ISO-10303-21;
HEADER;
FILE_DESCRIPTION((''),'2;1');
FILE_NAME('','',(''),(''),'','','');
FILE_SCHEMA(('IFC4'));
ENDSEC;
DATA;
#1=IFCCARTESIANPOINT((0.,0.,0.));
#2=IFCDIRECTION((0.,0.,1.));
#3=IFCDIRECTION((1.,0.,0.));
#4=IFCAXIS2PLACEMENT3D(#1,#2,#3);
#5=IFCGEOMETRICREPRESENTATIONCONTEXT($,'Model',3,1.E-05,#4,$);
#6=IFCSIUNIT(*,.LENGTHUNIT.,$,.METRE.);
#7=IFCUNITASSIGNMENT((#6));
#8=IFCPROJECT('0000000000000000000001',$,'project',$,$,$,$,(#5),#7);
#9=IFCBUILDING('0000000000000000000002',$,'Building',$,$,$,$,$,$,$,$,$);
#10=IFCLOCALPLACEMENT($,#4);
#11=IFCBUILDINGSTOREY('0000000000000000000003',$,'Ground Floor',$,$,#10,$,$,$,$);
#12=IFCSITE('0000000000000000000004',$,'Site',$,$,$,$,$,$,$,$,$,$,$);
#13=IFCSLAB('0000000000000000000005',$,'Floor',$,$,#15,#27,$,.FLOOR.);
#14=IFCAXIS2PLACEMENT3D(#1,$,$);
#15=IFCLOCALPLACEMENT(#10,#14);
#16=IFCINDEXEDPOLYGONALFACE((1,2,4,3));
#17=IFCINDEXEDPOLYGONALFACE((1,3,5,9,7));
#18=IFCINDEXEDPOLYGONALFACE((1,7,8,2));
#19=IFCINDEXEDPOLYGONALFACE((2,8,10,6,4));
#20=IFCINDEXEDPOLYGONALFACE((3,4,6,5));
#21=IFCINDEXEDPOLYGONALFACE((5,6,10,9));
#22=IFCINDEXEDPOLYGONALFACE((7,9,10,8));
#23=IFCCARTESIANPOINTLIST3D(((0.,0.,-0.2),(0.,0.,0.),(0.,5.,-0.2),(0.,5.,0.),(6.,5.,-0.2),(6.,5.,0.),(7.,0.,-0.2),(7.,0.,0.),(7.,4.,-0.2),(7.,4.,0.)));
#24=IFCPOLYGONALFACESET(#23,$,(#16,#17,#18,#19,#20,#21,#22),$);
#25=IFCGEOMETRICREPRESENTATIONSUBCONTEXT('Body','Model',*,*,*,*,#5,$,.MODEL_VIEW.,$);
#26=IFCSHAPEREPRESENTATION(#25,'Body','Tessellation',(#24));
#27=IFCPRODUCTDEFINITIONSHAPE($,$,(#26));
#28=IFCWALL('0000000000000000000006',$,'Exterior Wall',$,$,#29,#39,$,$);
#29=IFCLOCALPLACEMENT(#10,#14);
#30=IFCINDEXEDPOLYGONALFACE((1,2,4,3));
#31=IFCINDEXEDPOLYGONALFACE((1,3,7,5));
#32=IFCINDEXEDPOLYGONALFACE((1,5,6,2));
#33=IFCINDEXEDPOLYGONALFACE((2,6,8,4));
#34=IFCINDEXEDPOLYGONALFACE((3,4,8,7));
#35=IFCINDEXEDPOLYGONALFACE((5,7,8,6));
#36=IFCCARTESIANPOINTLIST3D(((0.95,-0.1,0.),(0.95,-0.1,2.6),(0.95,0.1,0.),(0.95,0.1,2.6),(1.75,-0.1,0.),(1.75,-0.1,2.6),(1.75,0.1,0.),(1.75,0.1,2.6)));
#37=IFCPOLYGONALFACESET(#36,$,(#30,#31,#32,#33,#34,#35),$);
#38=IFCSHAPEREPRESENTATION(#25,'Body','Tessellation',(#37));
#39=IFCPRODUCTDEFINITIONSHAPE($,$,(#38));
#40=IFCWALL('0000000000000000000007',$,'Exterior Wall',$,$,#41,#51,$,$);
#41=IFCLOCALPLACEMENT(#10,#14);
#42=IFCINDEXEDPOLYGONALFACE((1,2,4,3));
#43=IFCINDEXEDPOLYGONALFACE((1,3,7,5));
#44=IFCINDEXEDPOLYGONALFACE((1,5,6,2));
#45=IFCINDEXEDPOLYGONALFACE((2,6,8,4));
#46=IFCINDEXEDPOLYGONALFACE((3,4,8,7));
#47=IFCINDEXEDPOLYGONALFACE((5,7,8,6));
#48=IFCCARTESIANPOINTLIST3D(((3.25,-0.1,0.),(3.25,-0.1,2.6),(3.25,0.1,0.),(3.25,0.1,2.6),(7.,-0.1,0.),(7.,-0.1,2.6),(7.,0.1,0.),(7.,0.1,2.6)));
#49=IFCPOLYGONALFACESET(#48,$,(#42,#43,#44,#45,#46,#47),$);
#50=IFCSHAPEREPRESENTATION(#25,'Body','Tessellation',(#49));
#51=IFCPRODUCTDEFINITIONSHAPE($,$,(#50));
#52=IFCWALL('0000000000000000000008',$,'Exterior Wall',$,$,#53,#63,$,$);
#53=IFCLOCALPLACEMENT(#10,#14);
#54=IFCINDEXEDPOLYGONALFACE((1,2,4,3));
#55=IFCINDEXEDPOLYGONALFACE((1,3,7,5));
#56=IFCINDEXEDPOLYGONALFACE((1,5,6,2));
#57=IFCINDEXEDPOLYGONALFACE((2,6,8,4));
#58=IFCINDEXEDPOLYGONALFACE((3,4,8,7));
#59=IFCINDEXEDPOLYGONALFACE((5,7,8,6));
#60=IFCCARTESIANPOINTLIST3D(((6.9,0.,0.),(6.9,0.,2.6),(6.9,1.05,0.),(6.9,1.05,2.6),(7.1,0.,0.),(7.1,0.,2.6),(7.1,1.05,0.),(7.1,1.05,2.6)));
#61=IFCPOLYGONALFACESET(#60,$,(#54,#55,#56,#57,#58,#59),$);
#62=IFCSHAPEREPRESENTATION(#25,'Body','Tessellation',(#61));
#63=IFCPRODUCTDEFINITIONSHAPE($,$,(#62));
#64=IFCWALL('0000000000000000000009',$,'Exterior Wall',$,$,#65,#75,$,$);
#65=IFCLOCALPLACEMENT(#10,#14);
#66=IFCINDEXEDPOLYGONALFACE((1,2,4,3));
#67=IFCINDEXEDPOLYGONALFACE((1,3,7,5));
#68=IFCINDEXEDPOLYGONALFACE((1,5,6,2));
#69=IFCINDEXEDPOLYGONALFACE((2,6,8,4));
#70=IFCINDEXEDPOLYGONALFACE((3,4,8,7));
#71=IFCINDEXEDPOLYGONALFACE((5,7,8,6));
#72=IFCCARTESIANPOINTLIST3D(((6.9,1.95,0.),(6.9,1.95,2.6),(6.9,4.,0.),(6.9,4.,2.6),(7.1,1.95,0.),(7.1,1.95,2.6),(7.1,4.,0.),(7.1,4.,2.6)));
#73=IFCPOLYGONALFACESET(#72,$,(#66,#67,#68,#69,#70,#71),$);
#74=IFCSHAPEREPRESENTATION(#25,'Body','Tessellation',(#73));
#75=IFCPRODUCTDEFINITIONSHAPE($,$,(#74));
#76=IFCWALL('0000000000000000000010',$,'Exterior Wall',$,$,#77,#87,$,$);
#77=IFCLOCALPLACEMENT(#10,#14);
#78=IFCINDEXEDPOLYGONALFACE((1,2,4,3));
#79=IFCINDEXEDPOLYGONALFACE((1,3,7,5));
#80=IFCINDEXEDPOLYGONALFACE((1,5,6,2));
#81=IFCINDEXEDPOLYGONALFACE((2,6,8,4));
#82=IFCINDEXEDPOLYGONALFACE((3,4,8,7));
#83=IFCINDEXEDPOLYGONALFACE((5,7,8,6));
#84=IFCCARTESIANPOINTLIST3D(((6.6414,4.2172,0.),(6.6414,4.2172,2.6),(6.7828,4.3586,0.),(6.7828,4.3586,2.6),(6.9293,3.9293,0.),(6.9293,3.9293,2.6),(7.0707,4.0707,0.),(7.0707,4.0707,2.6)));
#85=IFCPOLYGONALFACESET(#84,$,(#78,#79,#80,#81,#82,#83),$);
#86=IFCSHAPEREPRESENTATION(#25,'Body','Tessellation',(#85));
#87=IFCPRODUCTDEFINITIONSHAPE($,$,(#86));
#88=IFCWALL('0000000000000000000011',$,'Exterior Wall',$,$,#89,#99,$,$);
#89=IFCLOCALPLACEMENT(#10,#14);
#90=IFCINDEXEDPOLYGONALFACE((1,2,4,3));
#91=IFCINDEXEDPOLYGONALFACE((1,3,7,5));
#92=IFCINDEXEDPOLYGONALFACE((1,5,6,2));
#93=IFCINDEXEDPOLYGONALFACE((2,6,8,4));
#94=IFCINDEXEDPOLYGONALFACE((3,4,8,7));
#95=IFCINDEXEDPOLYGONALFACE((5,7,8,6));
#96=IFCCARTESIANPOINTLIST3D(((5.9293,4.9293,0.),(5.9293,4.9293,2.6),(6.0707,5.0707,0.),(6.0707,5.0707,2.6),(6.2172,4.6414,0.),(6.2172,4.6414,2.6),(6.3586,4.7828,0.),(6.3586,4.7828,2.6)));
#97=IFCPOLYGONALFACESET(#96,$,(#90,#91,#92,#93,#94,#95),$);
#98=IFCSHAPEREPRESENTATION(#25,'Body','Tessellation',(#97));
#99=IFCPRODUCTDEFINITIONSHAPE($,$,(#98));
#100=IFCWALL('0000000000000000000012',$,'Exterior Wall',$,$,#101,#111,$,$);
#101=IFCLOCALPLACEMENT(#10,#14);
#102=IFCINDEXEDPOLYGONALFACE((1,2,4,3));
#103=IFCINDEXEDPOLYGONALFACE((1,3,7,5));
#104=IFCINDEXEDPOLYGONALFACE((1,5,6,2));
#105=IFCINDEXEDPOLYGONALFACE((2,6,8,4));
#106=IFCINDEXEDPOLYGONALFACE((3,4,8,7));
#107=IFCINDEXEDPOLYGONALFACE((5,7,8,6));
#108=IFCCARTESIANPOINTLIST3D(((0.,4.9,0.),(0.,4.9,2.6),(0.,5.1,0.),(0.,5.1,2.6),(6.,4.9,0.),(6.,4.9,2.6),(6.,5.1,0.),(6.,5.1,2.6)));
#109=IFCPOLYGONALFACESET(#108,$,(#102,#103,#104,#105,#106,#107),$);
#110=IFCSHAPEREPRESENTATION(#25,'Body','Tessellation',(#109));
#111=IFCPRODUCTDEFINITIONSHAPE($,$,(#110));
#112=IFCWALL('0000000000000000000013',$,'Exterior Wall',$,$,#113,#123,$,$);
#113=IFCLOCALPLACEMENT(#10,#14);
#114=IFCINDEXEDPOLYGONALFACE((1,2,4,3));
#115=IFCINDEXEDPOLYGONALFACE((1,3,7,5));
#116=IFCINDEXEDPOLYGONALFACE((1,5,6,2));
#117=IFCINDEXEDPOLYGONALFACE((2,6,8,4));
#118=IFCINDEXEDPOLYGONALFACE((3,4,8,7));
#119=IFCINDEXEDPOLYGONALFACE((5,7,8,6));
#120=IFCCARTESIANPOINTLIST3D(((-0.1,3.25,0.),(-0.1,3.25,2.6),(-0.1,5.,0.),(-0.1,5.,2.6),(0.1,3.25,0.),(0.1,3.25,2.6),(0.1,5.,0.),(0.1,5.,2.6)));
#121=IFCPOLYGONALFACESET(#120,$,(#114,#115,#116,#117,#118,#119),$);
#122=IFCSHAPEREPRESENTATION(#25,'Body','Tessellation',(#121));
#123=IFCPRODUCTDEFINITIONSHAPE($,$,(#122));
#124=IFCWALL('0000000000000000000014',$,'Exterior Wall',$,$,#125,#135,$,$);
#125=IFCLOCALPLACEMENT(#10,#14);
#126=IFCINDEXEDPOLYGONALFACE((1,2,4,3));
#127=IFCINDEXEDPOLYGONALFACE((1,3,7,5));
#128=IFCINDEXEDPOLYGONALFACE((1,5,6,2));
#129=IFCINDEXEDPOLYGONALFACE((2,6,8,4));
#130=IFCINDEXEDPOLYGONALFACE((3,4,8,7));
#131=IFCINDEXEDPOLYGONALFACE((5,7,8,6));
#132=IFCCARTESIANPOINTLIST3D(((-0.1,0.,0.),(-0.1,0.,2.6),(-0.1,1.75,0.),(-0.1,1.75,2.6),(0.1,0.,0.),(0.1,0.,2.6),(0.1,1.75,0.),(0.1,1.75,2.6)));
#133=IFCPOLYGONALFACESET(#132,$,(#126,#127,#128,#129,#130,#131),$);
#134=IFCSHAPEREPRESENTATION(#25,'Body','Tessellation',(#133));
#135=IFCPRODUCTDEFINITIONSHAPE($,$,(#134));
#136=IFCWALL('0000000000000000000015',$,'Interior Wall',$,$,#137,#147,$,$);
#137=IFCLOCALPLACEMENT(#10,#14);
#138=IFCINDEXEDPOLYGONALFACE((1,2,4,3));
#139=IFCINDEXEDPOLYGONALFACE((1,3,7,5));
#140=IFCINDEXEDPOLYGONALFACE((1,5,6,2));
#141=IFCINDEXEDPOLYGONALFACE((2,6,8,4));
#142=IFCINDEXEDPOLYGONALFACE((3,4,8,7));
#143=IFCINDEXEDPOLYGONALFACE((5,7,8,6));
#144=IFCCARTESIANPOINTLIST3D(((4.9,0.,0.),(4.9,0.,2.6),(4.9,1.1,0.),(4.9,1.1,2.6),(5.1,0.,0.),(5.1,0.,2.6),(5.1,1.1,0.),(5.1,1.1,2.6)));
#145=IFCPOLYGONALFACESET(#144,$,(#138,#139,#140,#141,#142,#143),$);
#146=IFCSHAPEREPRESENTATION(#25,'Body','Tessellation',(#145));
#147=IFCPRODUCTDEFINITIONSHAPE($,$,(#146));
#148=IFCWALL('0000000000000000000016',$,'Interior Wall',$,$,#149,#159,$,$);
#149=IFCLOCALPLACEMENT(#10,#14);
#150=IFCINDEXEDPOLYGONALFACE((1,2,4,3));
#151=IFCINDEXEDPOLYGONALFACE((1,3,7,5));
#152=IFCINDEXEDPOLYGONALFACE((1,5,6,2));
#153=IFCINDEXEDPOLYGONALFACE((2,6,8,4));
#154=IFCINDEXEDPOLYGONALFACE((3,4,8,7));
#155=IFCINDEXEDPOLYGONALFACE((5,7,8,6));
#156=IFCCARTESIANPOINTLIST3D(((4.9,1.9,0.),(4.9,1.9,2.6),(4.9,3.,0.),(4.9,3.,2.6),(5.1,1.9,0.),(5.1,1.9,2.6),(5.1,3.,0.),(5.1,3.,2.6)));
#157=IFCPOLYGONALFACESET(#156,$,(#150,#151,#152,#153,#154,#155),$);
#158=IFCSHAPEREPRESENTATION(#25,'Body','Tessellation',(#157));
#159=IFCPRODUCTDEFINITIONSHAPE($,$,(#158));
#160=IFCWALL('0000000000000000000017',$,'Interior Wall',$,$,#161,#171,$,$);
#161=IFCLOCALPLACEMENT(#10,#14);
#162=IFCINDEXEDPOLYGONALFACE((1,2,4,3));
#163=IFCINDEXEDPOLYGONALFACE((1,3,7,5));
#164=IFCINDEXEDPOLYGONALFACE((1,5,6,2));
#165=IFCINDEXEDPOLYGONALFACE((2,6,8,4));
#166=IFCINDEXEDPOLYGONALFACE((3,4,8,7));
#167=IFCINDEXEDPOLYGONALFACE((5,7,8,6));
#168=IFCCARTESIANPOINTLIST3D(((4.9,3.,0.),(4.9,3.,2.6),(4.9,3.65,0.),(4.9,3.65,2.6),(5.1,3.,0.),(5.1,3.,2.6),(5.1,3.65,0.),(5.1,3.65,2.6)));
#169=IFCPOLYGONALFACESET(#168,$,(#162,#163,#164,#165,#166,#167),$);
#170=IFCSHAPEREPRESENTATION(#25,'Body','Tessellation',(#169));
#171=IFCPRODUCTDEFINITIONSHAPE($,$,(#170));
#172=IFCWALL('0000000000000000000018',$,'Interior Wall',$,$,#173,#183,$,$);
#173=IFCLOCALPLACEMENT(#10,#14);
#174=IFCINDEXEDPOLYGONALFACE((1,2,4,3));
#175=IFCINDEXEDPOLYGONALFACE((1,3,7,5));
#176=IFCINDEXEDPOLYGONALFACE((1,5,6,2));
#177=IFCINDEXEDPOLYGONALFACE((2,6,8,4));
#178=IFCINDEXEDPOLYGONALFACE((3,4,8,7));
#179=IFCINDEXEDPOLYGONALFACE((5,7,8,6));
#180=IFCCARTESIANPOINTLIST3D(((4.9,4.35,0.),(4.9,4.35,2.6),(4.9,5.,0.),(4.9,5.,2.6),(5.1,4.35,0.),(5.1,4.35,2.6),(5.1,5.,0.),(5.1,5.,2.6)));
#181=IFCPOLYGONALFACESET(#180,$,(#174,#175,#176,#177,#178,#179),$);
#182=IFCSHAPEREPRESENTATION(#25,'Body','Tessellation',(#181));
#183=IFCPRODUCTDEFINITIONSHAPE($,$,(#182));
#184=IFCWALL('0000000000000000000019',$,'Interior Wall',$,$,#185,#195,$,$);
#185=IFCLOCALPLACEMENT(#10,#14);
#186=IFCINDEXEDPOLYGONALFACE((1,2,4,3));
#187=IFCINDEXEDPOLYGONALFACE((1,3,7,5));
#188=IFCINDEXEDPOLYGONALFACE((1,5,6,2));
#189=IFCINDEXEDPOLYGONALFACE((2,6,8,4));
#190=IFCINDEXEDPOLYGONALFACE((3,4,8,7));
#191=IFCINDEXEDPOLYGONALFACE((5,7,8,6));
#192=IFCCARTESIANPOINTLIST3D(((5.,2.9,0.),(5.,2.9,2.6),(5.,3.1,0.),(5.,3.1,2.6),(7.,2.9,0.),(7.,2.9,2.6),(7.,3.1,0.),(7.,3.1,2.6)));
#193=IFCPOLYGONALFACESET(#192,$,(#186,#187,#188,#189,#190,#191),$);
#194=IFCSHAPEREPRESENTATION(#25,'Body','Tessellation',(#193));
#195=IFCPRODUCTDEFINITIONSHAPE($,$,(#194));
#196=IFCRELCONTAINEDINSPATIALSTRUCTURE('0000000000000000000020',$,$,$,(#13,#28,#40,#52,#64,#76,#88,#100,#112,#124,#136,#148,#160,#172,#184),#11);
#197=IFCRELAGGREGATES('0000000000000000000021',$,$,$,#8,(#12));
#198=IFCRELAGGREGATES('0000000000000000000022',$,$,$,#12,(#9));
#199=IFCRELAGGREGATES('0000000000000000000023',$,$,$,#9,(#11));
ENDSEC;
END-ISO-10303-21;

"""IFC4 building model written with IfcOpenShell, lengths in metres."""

from ifc_helpers import new_model, si_unit, frame, origin_with_axes, place, context, subcontext, project, spatial, indexed_curve, outline, extrude, element, save


model = new_model("IFC4")

# Units and contexts
model_context = context("Model", 3, precision=1e-05, world=origin_with_axes())
body_context = subcontext(model_context, "Body", "Model", "MODEL_VIEW")
ifc_project = project(units=[si_unit("LENGTHUNIT", "METRE")], contexts=[model_context])

# Site, building, storey
site = spatial("IfcSite", under=ifc_project, Name="Site")
building = spatial("IfcBuilding", under=site, Name="Building")
storey_placement = place(None, origin_with_axes())
storey = spatial("IfcBuildingStorey", under=building, at=storey_placement, Name="Ground Floor")

# Slab
slab_placement = place(storey_placement, frame((0.0, 0.0, -0.2), z_axis=(0.0, 0.0, 1.0), x_axis=(1.0, 0.0, 0.0)))
element("IfcSlab", 1, at=slab_placement, inside=storey, Name="Floor", PredefinedType="FLOOR", context=body_context, shape_type="SweptSolid", body=[
    extrude(outline(indexed_curve([(0.0, 0.0), (7.0, 0.0), (7.0, 4.0), (6.0, 5.0), (0.0, 5.0)])), None, (0.0, 0.0, 1.0), 0.2),
])

# Walls
wall_1_placement = place(storey_placement, frame((0.95, 0.0, 0.0), z_axis=(0.0, 0.0, 1.0), x_axis=(1.0, 0.0, 0.0)))
element("IfcWall", 2, at=wall_1_placement, inside=storey, Name="Exterior Wall", context=body_context, shape_type="SweptSolid", body=[
    extrude(outline(indexed_curve([(0.0, 0.0), (0.0, 0.2), (0.8, 0.2), (0.8, 0.0), (0.0, 0.0)], self_intersect=False)), frame((0.0, -0.1, 0.0), z_axis=(0.0, 0.0, 1.0), x_axis=(1.0, 0.0, 0.0)), (0.0, 0.0, 1.0), 2.6),
])
wall_2_placement = place(storey_placement, frame((3.25, 0.0, 0.0), z_axis=(0.0, 0.0, 1.0), x_axis=(1.0, 0.0, 0.0)))
element("IfcWall", 3, at=wall_2_placement, inside=storey, Name="Exterior Wall", context=body_context, shape_type="SweptSolid", body=[
    extrude(outline(indexed_curve([(0.0, 0.0), (0.0, 0.2), (3.75, 0.2), (3.75, 0.0), (0.0, 0.0)], self_intersect=False)), frame((0.0, -0.1, 0.0), z_axis=(0.0, 0.0, 1.0), x_axis=(1.0, 0.0, 0.0)), (0.0, 0.0, 1.0), 2.6),
])
wall_3_placement = place(storey_placement, frame((7.0, 0.0, 0.0), z_axis=(0.0, 0.0, 1.0), x_axis=(0.0, 1.0, 0.0)))
element("IfcWall", 4, at=wall_3_placement, inside=storey, Name="Exterior Wall", context=body_context, shape_type="SweptSolid", body=[
    extrude(outline(indexed_curve([(0.0, 0.0), (0.0, 0.2), (1.05, 0.2), (1.05, 0.0), (0.0, 0.0)], self_intersect=False)), frame((0.0, -0.1, 0.0), z_axis=(0.0, 0.0, 1.0), x_axis=(1.0, 0.0, 0.0)), (0.0, 0.0, 1.0), 2.6),
])
wall_4_placement = place(storey_placement, frame((7.0, 1.95, 0.0), z_axis=(0.0, 0.0, 1.0), x_axis=(0.0, 1.0, 0.0)))
element("IfcWall", 5, at=wall_4_placement, inside=storey, Name="Exterior Wall", context=body_context, shape_type="SweptSolid", body=[
    extrude(outline(indexed_curve([(0.0, 0.0), (0.0, 0.2), (2.05, 0.2), (2.05, 0.0), (0.0, 0.0)], self_intersect=False)), frame((0.0, -0.1, 0.0), z_axis=(0.0, 0.0, 1.0), x_axis=(1.0, 0.0, 0.0)), (0.0, 0.0, 1.0), 2.6),
])
wall_5_placement = place(storey_placement, frame((7.0, 4.0, 0.0), z_axis=(0.0, 0.0, 1.0), x_axis=(-0.707107, 0.707107, 0.0)))
element("IfcWall", 6, at=wall_5_placement, inside=storey, Name="Exterior Wall", context=body_context, shape_type="SweptSolid", body=[
    extrude(outline(indexed_curve([(0.0, 0.0), (0.0, 0.2), (0.4071, 0.2), (0.4071, 0.0), (0.0, 0.0)], self_intersect=False)), frame((0.0, -0.1, 0.0), z_axis=(0.0, 0.0, 1.0), x_axis=(1.0, 0.0, 0.0)), (0.0, 0.0, 1.0), 2.6),
])
wall_6_placement = place(storey_placement, frame((6.2879, 4.7121, 0.0), z_axis=(0.0, 0.0, 1.0), x_axis=(-0.707107, 0.707107, 0.0)))
element("IfcWall", 7, at=wall_6_placement, inside=storey, Name="Exterior Wall", context=body_context, shape_type="SweptSolid", body=[
    extrude(outline(indexed_curve([(0.0, 0.0), (0.0, 0.2), (0.4071, 0.2), (0.4071, 0.0), (0.0, 0.0)], self_intersect=False)), frame((0.0, -0.1, 0.0), z_axis=(0.0, 0.0, 1.0), x_axis=(1.0, 0.0, 0.0)), (0.0, 0.0, 1.0), 2.6),
])
wall_7_placement = place(storey_placement, frame((6.0, 5.0, 0.0), z_axis=(0.0, 0.0, 1.0), x_axis=(-1.0, 0.0, 0.0)))
element("IfcWall", 8, at=wall_7_placement, inside=storey, Name="Exterior Wall", context=body_context, shape_type="SweptSolid", body=[
    extrude(outline(indexed_curve([(0.0, 0.0), (0.0, 0.2), (6.0, 0.2), (6.0, 0.0), (0.0, 0.0)], self_intersect=False)), frame((0.0, -0.1, 0.0), z_axis=(0.0, 0.0, 1.0), x_axis=(1.0, 0.0, 0.0)), (0.0, 0.0, 1.0), 2.6),
])
for number, where, z_axis, x_axis, name in (
    (9, (0.0, 5.0, 0.0), (0.0, 0.0, 1.0), (0.0, -1.0, 0.0), "Exterior Wall"),
    (10, (0.0, 1.75, 0.0), (0.0, 0.0, 1.0), (0.0, -1.0, 0.0), "Exterior Wall"),
):
    element("IfcWall", number, at=place(storey_placement, frame(where, z_axis=z_axis, x_axis=x_axis)), inside=storey, Name=name, context=body_context, shape_type="SweptSolid", body=[
        extrude(outline(indexed_curve([(0.0, 0.0), (0.0, 0.2), (1.75, 0.2), (1.75, 0.0), (0.0, 0.0)], self_intersect=False)), frame((0.0, -0.1, 0.0), z_axis=(0.0, 0.0, 1.0), x_axis=(1.0, 0.0, 0.0)), (0.0, 0.0, 1.0), 2.6),
    ])
for number, where, z_axis, x_axis, name in (
    (11, (5.0, 0.0, 0.0), (0.0, 0.0, 1.0), (0.0, 1.0, 0.0), "Interior Wall"),
    (12, (5.0, 1.9, 0.0), (0.0, 0.0, 1.0), (0.0, 1.0, 0.0), "Interior Wall"),
):
    element("IfcWall", number, at=place(storey_placement, frame(where, z_axis=z_axis, x_axis=x_axis)), inside=storey, Name=name, context=body_context, shape_type="SweptSolid", body=[
        extrude(outline(indexed_curve([(0.0, 0.0), (0.0, 0.2), (1.1, 0.2), (1.1, 0.0), (0.0, 0.0)], self_intersect=False)), frame((0.0, -0.1, 0.0), z_axis=(0.0, 0.0, 1.0), x_axis=(1.0, 0.0, 0.0)), (0.0, 0.0, 1.0), 2.6),
    ])
wall_8_placement = place(storey_placement, frame((5.0, 3.0, 0.0), z_axis=(0.0, 0.0, 1.0), x_axis=(0.0, 1.0, 0.0)))
element("IfcWall", 13, at=wall_8_placement, inside=storey, Name="Interior Wall", context=body_context, shape_type="SweptSolid", body=[
    extrude(outline(indexed_curve([(0.0, 0.0), (0.0, 0.2), (0.65, 0.2), (0.65, 0.0), (0.0, 0.0)], self_intersect=False)), frame((0.0, -0.1, 0.0), z_axis=(0.0, 0.0, 1.0), x_axis=(1.0, 0.0, 0.0)), (0.0, 0.0, 1.0), 2.6),
])
wall_9_placement = place(storey_placement, frame((5.0, 4.35, 0.0), z_axis=(0.0, 0.0, 1.0), x_axis=(0.0, 1.0, 0.0)))
element("IfcWall", 14, at=wall_9_placement, inside=storey, Name="Interior Wall", context=body_context, shape_type="SweptSolid", body=[
    extrude(outline(indexed_curve([(0.0, 0.0), (0.0, 0.2), (0.65, 0.2), (0.65, 0.0), (0.0, 0.0)], self_intersect=False)), frame((0.0, -0.1, 0.0), z_axis=(0.0, 0.0, 1.0), x_axis=(1.0, 0.0, 0.0)), (0.0, 0.0, 1.0), 2.6),
])
wall_10_placement = place(storey_placement, frame((7.0, 3.0, 0.0), z_axis=(0.0, 0.0, 1.0), x_axis=(-1.0, 0.0, 0.0)))
element("IfcWall", 15, at=wall_10_placement, inside=storey, Name="Interior Wall", context=body_context, shape_type="SweptSolid", body=[
    extrude(outline(indexed_curve([(0.0, 0.0), (0.0, 0.2), (2.0, 0.2), (2.0, 0.0), (0.0, 0.0)], self_intersect=False)), frame((0.0, -0.1, 0.0), z_axis=(0.0, 0.0, 1.0), x_axis=(1.0, 0.0, 0.0)), (0.0, 0.0, 1.0), 2.6),
])

save(model, "model.ifc")
